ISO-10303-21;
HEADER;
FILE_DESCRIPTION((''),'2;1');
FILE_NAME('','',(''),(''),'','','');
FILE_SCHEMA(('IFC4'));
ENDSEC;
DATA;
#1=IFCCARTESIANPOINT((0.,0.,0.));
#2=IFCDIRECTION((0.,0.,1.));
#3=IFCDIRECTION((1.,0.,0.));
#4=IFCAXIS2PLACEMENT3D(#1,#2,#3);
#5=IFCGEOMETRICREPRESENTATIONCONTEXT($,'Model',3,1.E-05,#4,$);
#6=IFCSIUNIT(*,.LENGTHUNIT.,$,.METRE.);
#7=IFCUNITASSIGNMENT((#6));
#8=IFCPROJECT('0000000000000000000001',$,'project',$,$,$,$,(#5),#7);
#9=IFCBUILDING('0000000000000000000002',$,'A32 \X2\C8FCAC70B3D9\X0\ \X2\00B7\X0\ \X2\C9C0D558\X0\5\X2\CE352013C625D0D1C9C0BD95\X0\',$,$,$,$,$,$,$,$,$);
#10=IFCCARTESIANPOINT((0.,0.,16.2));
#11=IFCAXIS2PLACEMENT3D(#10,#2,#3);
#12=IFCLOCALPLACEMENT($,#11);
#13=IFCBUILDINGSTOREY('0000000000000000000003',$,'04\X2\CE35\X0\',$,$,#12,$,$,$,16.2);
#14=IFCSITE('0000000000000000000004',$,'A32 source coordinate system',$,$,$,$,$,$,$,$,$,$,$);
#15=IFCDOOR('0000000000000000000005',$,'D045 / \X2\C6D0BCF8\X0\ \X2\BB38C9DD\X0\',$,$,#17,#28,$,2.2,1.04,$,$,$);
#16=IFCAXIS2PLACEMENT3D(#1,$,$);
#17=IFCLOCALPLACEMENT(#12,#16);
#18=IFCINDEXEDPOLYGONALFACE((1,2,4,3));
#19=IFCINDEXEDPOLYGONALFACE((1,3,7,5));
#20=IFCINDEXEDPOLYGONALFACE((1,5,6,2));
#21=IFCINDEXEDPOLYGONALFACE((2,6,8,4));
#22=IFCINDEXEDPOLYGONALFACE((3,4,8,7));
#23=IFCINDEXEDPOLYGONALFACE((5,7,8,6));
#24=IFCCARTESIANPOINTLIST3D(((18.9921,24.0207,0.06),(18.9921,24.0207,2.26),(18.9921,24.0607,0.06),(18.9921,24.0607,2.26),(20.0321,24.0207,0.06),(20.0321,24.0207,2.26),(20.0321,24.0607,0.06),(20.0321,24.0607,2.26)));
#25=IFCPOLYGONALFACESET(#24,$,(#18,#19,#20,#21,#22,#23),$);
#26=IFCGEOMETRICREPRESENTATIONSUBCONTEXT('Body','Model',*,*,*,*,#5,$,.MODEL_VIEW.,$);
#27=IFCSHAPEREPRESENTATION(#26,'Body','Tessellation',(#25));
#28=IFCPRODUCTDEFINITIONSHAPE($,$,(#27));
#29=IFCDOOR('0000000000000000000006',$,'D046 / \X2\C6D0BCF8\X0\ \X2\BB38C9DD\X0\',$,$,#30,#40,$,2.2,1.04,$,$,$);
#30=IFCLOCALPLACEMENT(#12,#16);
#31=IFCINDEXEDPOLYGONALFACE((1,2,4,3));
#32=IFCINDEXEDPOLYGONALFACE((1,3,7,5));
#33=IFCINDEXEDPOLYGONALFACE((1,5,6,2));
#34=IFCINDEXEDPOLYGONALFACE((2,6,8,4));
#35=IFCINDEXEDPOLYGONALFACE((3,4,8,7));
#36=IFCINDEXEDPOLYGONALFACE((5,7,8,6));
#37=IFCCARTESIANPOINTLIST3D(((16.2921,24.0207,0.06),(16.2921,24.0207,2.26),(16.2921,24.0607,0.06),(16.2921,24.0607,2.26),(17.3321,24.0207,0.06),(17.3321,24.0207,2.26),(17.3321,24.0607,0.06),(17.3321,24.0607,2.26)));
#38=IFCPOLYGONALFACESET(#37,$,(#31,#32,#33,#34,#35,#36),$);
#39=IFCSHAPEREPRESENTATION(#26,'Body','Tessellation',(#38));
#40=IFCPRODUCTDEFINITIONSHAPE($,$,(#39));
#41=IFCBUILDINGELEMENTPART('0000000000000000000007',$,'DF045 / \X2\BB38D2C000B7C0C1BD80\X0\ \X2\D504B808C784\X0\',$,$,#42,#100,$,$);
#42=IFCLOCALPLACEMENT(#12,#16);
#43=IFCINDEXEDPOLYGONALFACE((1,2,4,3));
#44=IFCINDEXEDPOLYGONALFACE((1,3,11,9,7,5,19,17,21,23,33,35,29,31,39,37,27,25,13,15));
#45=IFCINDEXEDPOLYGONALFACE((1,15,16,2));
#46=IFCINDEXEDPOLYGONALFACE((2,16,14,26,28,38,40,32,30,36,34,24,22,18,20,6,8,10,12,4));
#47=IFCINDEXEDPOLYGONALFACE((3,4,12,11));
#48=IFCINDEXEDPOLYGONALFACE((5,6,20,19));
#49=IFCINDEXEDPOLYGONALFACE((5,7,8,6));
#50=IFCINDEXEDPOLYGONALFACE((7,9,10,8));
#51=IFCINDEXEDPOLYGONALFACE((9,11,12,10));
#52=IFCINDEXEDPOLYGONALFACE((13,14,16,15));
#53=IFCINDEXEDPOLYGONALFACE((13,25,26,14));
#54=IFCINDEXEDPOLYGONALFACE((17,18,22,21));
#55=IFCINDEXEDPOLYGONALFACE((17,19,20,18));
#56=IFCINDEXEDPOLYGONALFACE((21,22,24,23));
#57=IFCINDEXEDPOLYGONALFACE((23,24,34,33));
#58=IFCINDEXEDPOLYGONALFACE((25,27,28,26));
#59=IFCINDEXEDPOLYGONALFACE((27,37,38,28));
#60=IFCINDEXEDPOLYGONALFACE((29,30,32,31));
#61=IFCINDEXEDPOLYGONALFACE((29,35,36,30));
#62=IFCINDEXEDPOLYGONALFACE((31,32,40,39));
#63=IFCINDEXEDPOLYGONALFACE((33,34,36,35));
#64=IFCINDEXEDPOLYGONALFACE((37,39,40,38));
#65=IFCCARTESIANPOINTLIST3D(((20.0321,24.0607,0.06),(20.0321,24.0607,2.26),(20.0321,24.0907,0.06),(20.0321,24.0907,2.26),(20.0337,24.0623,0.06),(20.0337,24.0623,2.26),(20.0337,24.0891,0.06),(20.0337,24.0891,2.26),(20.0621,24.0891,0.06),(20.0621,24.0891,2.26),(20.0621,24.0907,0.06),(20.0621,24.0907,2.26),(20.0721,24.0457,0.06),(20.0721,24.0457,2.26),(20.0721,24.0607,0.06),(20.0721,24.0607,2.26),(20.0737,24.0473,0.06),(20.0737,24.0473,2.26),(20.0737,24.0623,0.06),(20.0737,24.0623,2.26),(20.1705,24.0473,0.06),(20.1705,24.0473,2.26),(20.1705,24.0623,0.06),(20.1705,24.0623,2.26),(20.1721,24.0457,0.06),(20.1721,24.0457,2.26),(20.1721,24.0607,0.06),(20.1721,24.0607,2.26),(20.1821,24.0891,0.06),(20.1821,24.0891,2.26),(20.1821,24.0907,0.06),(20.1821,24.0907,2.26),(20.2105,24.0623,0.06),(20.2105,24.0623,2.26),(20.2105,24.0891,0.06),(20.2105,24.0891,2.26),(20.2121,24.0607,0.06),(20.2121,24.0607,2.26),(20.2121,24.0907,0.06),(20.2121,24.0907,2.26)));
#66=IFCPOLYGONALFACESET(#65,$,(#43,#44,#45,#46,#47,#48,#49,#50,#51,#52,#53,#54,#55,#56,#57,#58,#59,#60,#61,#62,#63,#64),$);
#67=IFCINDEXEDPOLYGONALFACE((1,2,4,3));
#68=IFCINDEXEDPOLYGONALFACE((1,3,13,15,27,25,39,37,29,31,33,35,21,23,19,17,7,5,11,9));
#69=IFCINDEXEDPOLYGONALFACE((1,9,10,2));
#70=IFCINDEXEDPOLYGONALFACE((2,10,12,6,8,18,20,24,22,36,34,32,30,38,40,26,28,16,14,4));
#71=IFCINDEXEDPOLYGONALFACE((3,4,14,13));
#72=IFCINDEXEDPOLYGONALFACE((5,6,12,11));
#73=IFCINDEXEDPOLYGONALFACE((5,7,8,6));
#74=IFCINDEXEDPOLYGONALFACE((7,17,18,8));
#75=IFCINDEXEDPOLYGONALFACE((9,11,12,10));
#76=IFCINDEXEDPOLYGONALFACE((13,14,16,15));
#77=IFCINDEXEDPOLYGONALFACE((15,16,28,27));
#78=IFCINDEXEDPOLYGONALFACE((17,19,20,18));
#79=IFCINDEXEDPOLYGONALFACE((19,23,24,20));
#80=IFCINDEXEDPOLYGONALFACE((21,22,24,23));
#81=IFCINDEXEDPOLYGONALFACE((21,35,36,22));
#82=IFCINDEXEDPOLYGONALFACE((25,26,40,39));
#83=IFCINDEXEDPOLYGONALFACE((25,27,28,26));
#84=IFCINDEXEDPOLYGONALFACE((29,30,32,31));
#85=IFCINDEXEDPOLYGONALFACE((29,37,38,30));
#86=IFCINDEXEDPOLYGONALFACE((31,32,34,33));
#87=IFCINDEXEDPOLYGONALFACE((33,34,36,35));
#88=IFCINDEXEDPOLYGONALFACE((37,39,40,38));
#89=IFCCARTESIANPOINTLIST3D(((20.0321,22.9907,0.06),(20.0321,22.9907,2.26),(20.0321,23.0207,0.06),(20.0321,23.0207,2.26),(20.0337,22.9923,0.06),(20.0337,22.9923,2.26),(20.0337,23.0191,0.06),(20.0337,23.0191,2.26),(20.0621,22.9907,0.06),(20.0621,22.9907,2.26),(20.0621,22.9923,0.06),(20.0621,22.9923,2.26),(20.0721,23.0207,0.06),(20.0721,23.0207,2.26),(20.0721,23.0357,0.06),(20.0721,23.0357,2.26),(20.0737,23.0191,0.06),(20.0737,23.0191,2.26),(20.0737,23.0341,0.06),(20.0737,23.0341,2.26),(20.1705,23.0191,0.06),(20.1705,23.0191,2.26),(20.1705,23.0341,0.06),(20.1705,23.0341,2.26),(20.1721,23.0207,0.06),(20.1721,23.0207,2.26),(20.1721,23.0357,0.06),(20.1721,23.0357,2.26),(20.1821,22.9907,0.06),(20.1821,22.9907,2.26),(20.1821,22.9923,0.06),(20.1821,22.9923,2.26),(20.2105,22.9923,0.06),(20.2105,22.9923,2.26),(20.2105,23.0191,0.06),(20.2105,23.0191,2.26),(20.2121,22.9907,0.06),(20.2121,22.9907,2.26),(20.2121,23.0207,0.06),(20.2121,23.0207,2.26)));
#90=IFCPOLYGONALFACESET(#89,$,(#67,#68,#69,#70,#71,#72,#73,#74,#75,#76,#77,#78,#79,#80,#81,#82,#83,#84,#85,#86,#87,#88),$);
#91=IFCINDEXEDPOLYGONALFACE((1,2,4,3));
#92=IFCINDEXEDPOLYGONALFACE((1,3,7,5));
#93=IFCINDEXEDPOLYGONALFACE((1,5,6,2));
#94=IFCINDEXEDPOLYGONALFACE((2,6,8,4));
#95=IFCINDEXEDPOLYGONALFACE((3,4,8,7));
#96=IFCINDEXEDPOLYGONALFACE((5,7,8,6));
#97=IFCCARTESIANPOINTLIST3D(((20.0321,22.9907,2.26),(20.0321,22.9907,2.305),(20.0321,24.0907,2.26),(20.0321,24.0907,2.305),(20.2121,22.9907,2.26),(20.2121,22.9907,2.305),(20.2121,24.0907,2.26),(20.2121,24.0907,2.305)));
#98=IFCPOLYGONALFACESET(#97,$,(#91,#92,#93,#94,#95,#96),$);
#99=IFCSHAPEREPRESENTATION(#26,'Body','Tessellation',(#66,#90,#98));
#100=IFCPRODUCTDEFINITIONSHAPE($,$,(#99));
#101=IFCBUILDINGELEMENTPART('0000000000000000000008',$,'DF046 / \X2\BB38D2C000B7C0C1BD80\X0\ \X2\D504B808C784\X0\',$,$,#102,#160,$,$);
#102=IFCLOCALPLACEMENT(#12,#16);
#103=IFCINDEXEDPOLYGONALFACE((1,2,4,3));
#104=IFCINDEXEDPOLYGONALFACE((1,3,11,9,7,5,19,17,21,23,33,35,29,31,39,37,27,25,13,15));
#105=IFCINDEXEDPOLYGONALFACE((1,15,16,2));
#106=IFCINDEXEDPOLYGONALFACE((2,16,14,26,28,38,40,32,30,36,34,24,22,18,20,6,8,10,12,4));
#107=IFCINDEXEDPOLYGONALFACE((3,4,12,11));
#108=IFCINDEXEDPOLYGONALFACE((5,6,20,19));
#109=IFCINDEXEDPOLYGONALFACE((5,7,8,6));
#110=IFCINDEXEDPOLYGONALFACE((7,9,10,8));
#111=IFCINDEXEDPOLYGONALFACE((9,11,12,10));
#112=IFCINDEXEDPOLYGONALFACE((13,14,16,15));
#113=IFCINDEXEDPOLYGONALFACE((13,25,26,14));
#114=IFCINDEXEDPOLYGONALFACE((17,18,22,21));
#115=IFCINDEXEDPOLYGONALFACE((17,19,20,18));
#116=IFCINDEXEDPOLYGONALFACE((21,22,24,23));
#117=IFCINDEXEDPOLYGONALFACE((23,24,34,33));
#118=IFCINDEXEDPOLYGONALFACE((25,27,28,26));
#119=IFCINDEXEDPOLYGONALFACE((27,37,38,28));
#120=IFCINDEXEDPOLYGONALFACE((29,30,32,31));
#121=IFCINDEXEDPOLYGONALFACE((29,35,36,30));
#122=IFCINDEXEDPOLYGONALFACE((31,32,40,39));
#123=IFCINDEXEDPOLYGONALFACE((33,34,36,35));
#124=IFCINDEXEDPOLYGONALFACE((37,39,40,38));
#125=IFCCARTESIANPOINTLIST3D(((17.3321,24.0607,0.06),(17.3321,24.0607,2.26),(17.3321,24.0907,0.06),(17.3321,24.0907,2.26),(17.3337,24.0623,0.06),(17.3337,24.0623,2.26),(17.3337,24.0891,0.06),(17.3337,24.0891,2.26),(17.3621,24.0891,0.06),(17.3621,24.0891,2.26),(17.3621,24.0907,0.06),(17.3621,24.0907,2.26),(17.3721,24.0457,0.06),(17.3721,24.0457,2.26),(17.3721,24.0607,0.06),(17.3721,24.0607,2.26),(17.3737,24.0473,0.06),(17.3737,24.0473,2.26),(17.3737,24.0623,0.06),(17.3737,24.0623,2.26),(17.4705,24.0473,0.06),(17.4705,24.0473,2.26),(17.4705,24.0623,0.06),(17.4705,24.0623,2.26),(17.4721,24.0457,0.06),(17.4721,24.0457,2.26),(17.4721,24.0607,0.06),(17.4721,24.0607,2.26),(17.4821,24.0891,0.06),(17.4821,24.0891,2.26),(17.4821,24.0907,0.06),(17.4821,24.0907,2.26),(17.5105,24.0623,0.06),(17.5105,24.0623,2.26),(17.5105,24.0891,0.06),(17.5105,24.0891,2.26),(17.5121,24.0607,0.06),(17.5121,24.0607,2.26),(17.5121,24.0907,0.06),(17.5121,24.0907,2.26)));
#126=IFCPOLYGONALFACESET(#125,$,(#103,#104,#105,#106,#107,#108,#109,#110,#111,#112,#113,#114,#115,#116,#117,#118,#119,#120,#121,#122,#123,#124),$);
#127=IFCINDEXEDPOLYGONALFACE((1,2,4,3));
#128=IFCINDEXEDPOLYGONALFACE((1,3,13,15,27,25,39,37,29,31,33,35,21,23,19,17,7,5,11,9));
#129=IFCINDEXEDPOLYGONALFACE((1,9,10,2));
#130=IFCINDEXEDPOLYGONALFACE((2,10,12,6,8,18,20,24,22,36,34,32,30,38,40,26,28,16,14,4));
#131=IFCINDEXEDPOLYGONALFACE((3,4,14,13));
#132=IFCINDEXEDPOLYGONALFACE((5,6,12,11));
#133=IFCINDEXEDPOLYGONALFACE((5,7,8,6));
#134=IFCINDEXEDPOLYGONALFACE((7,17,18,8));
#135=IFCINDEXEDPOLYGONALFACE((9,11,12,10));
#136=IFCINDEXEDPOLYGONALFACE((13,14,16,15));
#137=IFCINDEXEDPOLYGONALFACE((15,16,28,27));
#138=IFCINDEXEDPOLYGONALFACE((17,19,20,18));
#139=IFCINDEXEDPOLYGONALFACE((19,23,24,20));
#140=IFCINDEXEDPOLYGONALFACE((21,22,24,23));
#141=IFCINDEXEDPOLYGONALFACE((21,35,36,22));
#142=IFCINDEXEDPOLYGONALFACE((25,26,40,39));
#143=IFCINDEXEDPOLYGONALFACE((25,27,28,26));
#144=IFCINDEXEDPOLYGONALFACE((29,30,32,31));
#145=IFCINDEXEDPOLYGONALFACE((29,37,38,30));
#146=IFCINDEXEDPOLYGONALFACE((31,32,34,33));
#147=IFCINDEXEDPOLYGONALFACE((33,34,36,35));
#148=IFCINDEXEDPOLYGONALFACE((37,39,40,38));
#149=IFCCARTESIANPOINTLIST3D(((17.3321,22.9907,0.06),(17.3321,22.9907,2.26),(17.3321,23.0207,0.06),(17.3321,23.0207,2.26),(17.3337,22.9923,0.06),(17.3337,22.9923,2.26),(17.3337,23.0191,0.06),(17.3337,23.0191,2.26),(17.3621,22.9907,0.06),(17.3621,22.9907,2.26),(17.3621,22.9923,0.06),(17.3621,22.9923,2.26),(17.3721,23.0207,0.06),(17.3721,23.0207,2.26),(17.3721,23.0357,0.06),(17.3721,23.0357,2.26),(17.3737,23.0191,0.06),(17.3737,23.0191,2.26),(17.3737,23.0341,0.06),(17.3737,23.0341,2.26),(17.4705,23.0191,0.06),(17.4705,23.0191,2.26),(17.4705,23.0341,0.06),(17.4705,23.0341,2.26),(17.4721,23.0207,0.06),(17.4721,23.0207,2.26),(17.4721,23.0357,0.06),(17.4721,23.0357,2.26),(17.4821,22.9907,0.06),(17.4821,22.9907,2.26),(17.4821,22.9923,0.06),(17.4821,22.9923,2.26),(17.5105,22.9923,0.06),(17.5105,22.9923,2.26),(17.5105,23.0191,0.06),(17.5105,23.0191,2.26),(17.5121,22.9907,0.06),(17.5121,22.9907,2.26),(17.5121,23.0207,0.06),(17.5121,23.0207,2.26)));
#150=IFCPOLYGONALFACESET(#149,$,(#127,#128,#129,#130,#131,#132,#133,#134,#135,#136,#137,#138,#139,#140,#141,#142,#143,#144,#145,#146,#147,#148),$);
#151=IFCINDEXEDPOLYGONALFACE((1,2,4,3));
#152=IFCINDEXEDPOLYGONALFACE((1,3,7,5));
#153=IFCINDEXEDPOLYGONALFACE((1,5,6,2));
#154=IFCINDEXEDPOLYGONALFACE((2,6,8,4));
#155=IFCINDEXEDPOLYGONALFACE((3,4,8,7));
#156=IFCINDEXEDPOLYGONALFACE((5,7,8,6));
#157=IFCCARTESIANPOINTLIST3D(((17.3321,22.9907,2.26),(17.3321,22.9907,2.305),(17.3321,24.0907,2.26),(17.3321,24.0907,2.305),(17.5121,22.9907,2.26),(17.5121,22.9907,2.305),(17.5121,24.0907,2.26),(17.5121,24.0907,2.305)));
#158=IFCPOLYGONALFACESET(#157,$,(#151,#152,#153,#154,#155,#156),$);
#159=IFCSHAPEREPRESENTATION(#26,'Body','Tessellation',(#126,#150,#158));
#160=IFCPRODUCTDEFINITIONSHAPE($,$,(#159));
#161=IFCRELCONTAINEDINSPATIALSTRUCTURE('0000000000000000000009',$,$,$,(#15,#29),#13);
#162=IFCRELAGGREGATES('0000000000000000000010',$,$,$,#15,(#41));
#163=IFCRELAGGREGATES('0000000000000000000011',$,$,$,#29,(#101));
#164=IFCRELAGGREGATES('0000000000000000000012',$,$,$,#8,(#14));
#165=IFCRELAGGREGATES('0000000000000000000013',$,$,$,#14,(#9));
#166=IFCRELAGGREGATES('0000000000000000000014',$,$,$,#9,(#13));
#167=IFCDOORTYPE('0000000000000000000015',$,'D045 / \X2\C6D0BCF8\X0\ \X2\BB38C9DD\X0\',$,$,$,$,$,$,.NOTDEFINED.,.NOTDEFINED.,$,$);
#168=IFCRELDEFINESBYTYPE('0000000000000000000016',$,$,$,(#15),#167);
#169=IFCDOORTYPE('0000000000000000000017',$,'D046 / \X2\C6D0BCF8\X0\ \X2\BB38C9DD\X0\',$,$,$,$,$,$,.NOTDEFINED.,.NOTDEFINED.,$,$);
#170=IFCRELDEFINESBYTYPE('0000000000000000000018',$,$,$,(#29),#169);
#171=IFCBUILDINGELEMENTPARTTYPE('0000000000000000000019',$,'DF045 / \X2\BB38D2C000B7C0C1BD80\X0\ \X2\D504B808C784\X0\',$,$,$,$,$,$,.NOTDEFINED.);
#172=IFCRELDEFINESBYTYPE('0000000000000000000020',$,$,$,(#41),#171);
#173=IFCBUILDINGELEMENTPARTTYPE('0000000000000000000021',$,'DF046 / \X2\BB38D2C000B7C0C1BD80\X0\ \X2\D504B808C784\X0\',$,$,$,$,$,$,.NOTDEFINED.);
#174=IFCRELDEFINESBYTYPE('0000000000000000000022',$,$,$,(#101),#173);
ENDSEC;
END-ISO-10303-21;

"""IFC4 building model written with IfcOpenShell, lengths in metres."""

from ifc_helpers import new_model, si_unit, frame, origin, origin_with_axes, place, context, subcontext, project, spatial, polyline, outline, extrude, source, transform, mapped, type_object, type_shapes, element, aggregate, save


model = new_model("IFC4")

# Units and contexts
model_context = context("Model", 3, precision=1e-05, world=origin_with_axes())
body_context = subcontext(model_context, "Body", "Model", "MODEL_VIEW")
ifc_project = project(units=[si_unit("LENGTHUNIT", "METRE")], contexts=[model_context])

# Site, building, storey
storey_placement = place(None, frame((0.0, 0.0, 16.2), z_axis=(0.0, 0.0, 1.0), x_axis=(1.0, 0.0, 0.0)))
site = spatial("IfcSite", under=ifc_project, Name="A32 source coordinate system")
building = spatial("IfcBuilding", under=site, Name="A32 주거동 · 지하5층–옥탑지붕")
storey = spatial("IfcBuildingStorey", under=building, at=storey_placement, Name="04층", Elevation=16.2)

# Doors
door_type_1 = type_object("IfcDoorType", Name="D045 / 원본 문짝", OperationType="NOTDEFINED", PredefinedType="NOTDEFINED")
shared_shape_1 = source(origin(), body_context, "Body", "SweptSolid", [
    extrude(outline(polyline([(20.0321, 24.0607), (20.0321, 24.0207), (18.9921, 24.0207), (18.9921, 24.0607), (20.0321, 24.0607)])), frame((0.0, 0.0, 0.06)), (0.0, 0.0, 1.0), 2.2),
])
type_shapes(door_type_1, [shared_shape_1])
door_1_placement = place(storey_placement, origin_with_axes())
door_1 = element("IfcDoor", 1, at=door_1_placement, inside=storey, type_object=door_type_1, Name="D045 / 원본 문짝", OverallHeight=2.2, OverallWidth=1.04, context=body_context, shape_type="MappedRepresentation", body=[
    mapped(shared_shape_1, transform((0.0, 0.0, 0.0), scale=1.0)),
])
door_type_2 = type_object("IfcDoorType", Name="D046 / 원본 문짝", OperationType="NOTDEFINED", PredefinedType="NOTDEFINED")
shared_shape_2 = source(origin(), body_context, "Body", "SweptSolid", [
    extrude(outline(polyline([(17.3321, 24.0607), (17.3321, 24.0207), (16.2921, 24.0207), (16.2921, 24.0607), (17.3321, 24.0607)])), frame((0.0, 0.0, 0.06)), (0.0, 0.0, 1.0), 2.2),
])
type_shapes(door_type_2, [shared_shape_2])
door_2_placement = place(storey_placement, origin_with_axes())
door_2 = element("IfcDoor", 2, at=door_2_placement, inside=storey, type_object=door_type_2, Name="D046 / 원본 문짝", OverallHeight=2.2, OverallWidth=1.04, context=body_context, shape_type="MappedRepresentation", body=[
    mapped(shared_shape_2, transform((0.0, 0.0, 0.0), scale=1.0)),
])

# Building element parts
building_element_part_type_1 = type_object("IfcBuildingElementPartType", Name="DF045 / 문틀·상부 프레임", PredefinedType="NOTDEFINED")
shared_shape_3 = source(origin(), body_context, "Body", "SweptSolid", [
    extrude(outline(polyline([(20.0337, 24.0891), (20.0337, 24.0623), (20.0737, 24.0623), (20.0737, 24.0473), (20.1705, 24.0473), (20.1705, 24.0623), (20.2105, 24.0623), (20.2105, 24.0891), (20.1821, 24.0891), (20.1821, 24.0907), (20.2121, 24.0907), (20.2121, 24.0607), (20.1721, 24.0607), (20.1721, 24.0457), (20.0721, 24.0457), (20.0721, 24.0607), (20.0321, 24.0607), (20.0321, 24.0907), (20.0621, 24.0907), (20.0621, 24.0891), (20.0337, 24.0891)])), frame((0.0, 0.0, 0.06)), (0.0, 0.0, 1.0), 2.2),
    extrude(outline(polyline([(20.0621, 22.9907), (20.0321, 22.9907), (20.0321, 23.0207), (20.0721, 23.0207), (20.0721, 23.0357), (20.1721, 23.0357), (20.1721, 23.0207), (20.2121, 23.0207), (20.2121, 22.9907), (20.1821, 22.9907), (20.1821, 22.9923), (20.2105, 22.9923), (20.2105, 23.0191), (20.1705, 23.0191), (20.1705, 23.0341), (20.0737, 23.0341), (20.0737, 23.0191), (20.0337, 23.0191), (20.0337, 22.9923), (20.0621, 22.9923), (20.0621, 22.9907)])), frame((0.0, 0.0, 0.06)), (0.0, 0.0, 1.0), 2.2),
    extrude(outline(polyline([(20.0321, 22.9907), (20.0321, 24.0907), (20.2121, 24.0907), (20.2121, 22.9907), (20.0321, 22.9907)])), frame((0.0, 0.0, 2.26)), (0.0, 0.0, 1.0), 0.045),
])
type_shapes(building_element_part_type_1, [shared_shape_3])
building_element_part_1_placement = place(door_1_placement, origin_with_axes())
building_element_part_1 = element("IfcBuildingElementPart", 3, at=building_element_part_1_placement, type_object=building_element_part_type_1, Name="DF045 / 문틀·상부 프레임", context=body_context, shape_type="MappedRepresentation", body=[
    mapped(shared_shape_3, transform((0.0, 0.0, 0.0), scale=1.0)),
])
aggregate(door_1, [building_element_part_1])
building_element_part_type_2 = type_object("IfcBuildingElementPartType", Name="DF046 / 문틀·상부 프레임", PredefinedType="NOTDEFINED")
shared_shape_4 = source(origin(), body_context, "Body", "SweptSolid", [
    extrude(outline(polyline([(17.3337, 24.0891), (17.3337, 24.0623), (17.3737, 24.0623), (17.3737, 24.0473), (17.4705, 24.0473), (17.4705, 24.0623), (17.5105, 24.0623), (17.5105, 24.0891), (17.4821, 24.0891), (17.4821, 24.0907), (17.5121, 24.0907), (17.5121, 24.0607), (17.4721, 24.0607), (17.4721, 24.0457), (17.3721, 24.0457), (17.3721, 24.0607), (17.3321, 24.0607), (17.3321, 24.0907), (17.3621, 24.0907), (17.3621, 24.0891), (17.3337, 24.0891)])), frame((0.0, 0.0, 0.06)), (0.0, 0.0, 1.0), 2.2),
    extrude(outline(polyline([(17.3621, 22.9907), (17.3321, 22.9907), (17.3321, 23.0207), (17.3721, 23.0207), (17.3721, 23.0357), (17.4721, 23.0357), (17.4721, 23.0207), (17.5121, 23.0207), (17.5121, 22.9907), (17.4821, 22.9907), (17.4821, 22.9923), (17.5105, 22.9923), (17.5105, 23.0191), (17.4705, 23.0191), (17.4705, 23.0341), (17.3737, 23.0341), (17.3737, 23.0191), (17.3337, 23.0191), (17.3337, 22.9923), (17.3621, 22.9923), (17.3621, 22.9907)])), frame((0.0, 0.0, 0.06)), (0.0, 0.0, 1.0), 2.2),
    extrude(outline(polyline([(17.3321, 22.9907), (17.3321, 24.0907), (17.5121, 24.0907), (17.5121, 22.9907), (17.3321, 22.9907)])), frame((0.0, 0.0, 2.26)), (0.0, 0.0, 1.0), 0.045),
])
type_shapes(building_element_part_type_2, [shared_shape_4])
building_element_part_2_placement = place(door_2_placement, origin_with_axes())
building_element_part_2 = element("IfcBuildingElementPart", 4, at=building_element_part_2_placement, type_object=building_element_part_type_2, Name="DF046 / 문틀·상부 프레임", context=body_context, shape_type="MappedRepresentation", body=[
    mapped(shared_shape_4, transform((0.0, 0.0, 0.0), scale=1.0)),
])
aggregate(door_2, [building_element_part_2])

save(model, "model.ifc")
